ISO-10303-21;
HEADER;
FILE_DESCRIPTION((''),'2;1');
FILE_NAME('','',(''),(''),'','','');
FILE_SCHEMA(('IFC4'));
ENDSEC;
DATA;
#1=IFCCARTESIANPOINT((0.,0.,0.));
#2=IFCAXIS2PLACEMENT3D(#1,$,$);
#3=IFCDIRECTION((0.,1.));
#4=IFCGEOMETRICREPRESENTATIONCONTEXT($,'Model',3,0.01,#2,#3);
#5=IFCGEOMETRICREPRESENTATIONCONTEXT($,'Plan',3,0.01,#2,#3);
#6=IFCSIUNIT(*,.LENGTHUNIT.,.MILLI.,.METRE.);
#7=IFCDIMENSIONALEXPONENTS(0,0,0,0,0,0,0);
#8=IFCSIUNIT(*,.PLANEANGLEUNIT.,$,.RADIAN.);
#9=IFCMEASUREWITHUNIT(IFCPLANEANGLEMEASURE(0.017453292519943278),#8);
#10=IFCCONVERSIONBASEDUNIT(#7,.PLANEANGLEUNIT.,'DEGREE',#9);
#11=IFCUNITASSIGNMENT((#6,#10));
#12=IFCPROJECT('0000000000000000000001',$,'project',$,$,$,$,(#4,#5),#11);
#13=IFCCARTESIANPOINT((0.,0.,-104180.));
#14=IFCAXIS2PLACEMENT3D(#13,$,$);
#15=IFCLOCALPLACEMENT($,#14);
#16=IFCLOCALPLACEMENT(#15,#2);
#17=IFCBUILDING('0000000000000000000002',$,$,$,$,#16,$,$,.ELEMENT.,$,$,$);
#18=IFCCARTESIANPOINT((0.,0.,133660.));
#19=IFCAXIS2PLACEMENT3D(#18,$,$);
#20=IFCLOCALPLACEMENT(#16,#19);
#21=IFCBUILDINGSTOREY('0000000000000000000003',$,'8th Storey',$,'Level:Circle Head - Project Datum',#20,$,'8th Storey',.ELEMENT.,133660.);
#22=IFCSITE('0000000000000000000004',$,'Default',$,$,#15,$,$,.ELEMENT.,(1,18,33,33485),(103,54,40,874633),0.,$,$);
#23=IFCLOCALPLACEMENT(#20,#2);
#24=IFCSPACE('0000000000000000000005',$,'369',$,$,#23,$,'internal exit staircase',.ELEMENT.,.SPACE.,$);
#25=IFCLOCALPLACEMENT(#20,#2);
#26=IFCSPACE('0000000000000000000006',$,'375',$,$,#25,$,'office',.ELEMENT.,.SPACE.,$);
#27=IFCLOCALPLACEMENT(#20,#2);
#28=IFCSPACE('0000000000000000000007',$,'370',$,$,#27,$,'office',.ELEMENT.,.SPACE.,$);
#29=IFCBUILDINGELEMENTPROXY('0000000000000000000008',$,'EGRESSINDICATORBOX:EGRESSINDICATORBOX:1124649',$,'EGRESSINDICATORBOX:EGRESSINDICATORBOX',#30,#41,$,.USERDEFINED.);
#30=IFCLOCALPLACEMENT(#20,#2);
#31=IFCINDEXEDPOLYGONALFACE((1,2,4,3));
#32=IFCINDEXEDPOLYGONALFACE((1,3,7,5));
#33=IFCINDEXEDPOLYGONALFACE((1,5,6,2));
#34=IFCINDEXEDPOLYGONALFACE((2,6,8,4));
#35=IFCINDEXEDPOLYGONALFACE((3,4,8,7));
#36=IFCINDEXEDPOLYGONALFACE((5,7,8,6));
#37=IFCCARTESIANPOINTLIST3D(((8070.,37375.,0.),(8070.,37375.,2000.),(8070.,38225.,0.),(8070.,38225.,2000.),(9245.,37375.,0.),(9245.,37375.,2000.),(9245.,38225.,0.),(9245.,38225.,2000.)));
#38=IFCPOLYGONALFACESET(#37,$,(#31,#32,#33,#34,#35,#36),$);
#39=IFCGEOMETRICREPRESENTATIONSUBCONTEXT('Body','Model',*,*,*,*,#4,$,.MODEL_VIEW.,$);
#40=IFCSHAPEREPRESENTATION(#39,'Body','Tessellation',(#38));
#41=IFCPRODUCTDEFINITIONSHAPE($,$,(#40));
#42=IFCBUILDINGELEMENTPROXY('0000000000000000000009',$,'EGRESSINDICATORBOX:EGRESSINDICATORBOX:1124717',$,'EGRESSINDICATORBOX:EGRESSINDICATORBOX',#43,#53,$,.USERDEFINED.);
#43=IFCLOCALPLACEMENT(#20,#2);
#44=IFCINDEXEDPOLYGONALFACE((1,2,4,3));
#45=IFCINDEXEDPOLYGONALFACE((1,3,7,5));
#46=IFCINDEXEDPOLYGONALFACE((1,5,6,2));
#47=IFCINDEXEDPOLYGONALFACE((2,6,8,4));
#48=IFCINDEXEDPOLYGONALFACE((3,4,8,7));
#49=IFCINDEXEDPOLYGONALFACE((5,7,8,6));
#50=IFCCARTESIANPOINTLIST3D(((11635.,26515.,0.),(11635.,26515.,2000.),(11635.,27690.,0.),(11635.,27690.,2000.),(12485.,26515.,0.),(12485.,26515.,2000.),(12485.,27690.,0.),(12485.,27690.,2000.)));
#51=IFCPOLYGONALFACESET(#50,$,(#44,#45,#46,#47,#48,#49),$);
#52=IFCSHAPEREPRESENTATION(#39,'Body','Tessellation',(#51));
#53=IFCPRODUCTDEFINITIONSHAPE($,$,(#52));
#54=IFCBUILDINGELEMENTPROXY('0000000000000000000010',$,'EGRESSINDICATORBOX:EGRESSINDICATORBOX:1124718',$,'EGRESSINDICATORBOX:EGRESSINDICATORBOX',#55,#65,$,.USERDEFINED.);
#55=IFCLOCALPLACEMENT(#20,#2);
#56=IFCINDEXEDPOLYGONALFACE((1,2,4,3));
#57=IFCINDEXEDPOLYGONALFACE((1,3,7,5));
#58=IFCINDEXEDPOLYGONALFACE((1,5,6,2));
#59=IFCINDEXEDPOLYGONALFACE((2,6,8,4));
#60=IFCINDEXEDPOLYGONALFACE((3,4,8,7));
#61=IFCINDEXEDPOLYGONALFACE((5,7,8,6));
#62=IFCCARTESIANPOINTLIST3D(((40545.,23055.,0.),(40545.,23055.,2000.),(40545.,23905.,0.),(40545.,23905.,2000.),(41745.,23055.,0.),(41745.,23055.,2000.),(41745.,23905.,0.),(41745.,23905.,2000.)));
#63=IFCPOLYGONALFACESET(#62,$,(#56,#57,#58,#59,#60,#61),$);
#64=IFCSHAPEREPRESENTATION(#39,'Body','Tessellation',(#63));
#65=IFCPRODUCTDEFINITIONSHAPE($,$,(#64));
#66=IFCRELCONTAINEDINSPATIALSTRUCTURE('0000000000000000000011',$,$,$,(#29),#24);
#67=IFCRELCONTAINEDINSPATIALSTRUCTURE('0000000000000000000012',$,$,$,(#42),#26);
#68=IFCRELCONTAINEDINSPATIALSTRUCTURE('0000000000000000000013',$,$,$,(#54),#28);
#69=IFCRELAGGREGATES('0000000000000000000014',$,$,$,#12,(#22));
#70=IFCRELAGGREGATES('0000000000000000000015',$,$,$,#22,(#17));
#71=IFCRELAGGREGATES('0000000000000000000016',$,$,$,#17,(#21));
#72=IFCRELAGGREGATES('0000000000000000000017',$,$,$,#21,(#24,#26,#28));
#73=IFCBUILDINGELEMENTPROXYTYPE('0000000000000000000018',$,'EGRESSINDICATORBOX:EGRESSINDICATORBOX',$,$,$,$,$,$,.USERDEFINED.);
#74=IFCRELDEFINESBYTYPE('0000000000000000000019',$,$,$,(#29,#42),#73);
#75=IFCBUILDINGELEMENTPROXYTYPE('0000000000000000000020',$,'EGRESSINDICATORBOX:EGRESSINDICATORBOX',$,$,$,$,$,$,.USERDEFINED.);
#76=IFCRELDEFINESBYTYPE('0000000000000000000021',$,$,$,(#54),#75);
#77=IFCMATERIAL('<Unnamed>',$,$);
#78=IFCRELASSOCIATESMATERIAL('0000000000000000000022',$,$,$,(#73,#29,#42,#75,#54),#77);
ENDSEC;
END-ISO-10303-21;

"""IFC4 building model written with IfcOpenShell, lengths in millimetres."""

from ifc_helpers import new_model, entity, si_unit, converted_unit, direction, frame, origin, place, context, subcontext, project, spatial, indexed_curve, outline, extrude, source, transform, mapped, material, type_object, type_shapes, element, save


model = new_model("IFC4")

# Units and contexts
model_context = context("Model", 3, precision=0.01, world=origin(), true_north=direction((0.0, 1.0)))
plan_context = context("Plan", 3, precision=0.01, world=origin(), true_north=direction((0.0, 1.0)))
body_context = subcontext(model_context, "Body", "Model", "MODEL_VIEW")
ifc_project = project(units=[si_unit("LENGTHUNIT", "METRE", prefix="MILLI"), converted_unit("PLANEANGLEUNIT", "DEGREE", entity("IfcPlaneAngleMeasure", 0.017453292519943278), si_unit("PLANEANGLEUNIT", "RADIAN"), dimensions=[0, 0, 0, 0, 0, 0, 0])], contexts=[model_context, plan_context])

# Site, building, storey
site_placement = place(None, frame((0.0, 0.0, -104180.0)))
site = spatial("IfcSite", under=ifc_project, at=site_placement, Name="Default", CompositionType="ELEMENT", RefLatitude=(1, 18, 33, 33485), RefLongitude=(103, 54, 40, 874633), RefElevation=0.0)
building_placement = place(site_placement, origin())
building = spatial("IfcBuilding", under=site, at=building_placement, CompositionType="ELEMENT")
storey_placement = place(building_placement, frame((0.0, 0.0, 133660.0)))
storey = spatial("IfcBuildingStorey", under=building, at=storey_placement, Name="8th Storey", ObjectType="Level:Circle Head - Project Datum", LongName="8th Storey", CompositionType="ELEMENT", Elevation=133660.0)

# Shared definitions
ifc_material_1 = material(Name="<Unnamed>")

# Shared definitions
building_element_proxy_type_1 = type_object("IfcBuildingElementProxyType", Name="EGRESSINDICATORBOX:EGRESSINDICATORBOX", PredefinedType="USERDEFINED", material=ifc_material_1)
shared_shape_1 = source(origin(), body_context, "Body", "SweptSolid", [
    extrude(outline(indexed_curve([(-425.0, -587.5), (425.0, -587.5), (425.0, 587.5), (-425.0, 587.5), (-425.0, -587.5)], self_intersect=False)), frame((0.0, 0.0, 0.0), z_axis=(0.0, 0.0, 1.0), x_axis=(-1.0, 0.0, 0.0)), (0.0, 0.0, 1.0), 2000.0),
])
type_shapes(building_element_proxy_type_1, [shared_shape_1])

# Shared definitions
space_1_placement = place(storey_placement, origin())
space_1 = spatial("IfcSpace", under=storey, at=space_1_placement, Name="369", LongName="internal exit staircase", CompositionType="ELEMENT", PredefinedType="SPACE")

# Building element proxy
proxy_1_placement = place(space_1_placement, frame((8657.5, 37800.0, 0.0), z_axis=(0.0, 0.0, 1.0), x_axis=(0.0, 1.0, 0.0)))
element("IfcBuildingElementProxy", 1, at=proxy_1_placement, inside=space_1, type_object=building_element_proxy_type_1, material=ifc_material_1, Name="EGRESSINDICATORBOX:EGRESSINDICATORBOX:1124649", ObjectType="EGRESSINDICATORBOX:EGRESSINDICATORBOX", PredefinedType="USERDEFINED", context=body_context, shape_type="MappedRepresentation", body=[
    mapped(shared_shape_1, transform((0.0, 0.0, 0.0), scale=1.0)),
])

# Shared definitions
space_2_placement = place(storey_placement, origin())
space_2 = spatial("IfcSpace", under=storey, at=space_2_placement, Name="375", LongName="office", CompositionType="ELEMENT", PredefinedType="SPACE")

# Building element proxy
proxy_2_placement = place(space_2_placement, frame((12060.0, 27102.5, 0.0)))
element("IfcBuildingElementProxy", 2, at=proxy_2_placement, inside=space_2, type_object=building_element_proxy_type_1, material=ifc_material_1, Name="EGRESSINDICATORBOX:EGRESSINDICATORBOX:1124717", ObjectType="EGRESSINDICATORBOX:EGRESSINDICATORBOX", PredefinedType="USERDEFINED", context=body_context, shape_type="MappedRepresentation", body=[
    mapped(shared_shape_1, transform((0.0, 0.0, 0.0), scale=1.0)),
])

# Shared definitions
space_3_placement = place(storey_placement, origin())
space_3 = spatial("IfcSpace", under=storey, at=space_3_placement, Name="370", LongName="office", CompositionType="ELEMENT", PredefinedType="SPACE")

# Building element proxy
building_element_proxy_type_2 = type_object("IfcBuildingElementProxyType", Name="EGRESSINDICATORBOX:EGRESSINDICATORBOX", PredefinedType="USERDEFINED", material=ifc_material_1)
shared_shape_2 = source(origin(), body_context, "Body", "SweptSolid", [
    extrude(outline(indexed_curve([(-600.0, -425.0), (600.0, -425.0), (600.0, 425.0), (-600.0, 425.0), (-600.0, -425.0)], self_intersect=False)), frame((0.0, 0.0, 0.0), z_axis=(0.0, 0.0, 1.0), x_axis=(0.0, 1.0, 0.0)), (0.0, 0.0, 1.0), 2000.0),
])
type_shapes(building_element_proxy_type_2, [shared_shape_2])
proxy_3_placement = place(space_3_placement, frame((41145.0, 23480.0, 0.0), z_axis=(0.0, 0.0, 1.0), x_axis=(0.0, -1.0, 0.0)))
element("IfcBuildingElementProxy", 3, at=proxy_3_placement, inside=space_3, type_object=building_element_proxy_type_2, material=ifc_material_1, Name="EGRESSINDICATORBOX:EGRESSINDICATORBOX:1124718", ObjectType="EGRESSINDICATORBOX:EGRESSINDICATORBOX", PredefinedType="USERDEFINED", context=body_context, shape_type="MappedRepresentation", body=[
    mapped(shared_shape_2, transform((0.0, 0.0, 0.0), scale=1.0)),
])

save(model, "model.ifc")
